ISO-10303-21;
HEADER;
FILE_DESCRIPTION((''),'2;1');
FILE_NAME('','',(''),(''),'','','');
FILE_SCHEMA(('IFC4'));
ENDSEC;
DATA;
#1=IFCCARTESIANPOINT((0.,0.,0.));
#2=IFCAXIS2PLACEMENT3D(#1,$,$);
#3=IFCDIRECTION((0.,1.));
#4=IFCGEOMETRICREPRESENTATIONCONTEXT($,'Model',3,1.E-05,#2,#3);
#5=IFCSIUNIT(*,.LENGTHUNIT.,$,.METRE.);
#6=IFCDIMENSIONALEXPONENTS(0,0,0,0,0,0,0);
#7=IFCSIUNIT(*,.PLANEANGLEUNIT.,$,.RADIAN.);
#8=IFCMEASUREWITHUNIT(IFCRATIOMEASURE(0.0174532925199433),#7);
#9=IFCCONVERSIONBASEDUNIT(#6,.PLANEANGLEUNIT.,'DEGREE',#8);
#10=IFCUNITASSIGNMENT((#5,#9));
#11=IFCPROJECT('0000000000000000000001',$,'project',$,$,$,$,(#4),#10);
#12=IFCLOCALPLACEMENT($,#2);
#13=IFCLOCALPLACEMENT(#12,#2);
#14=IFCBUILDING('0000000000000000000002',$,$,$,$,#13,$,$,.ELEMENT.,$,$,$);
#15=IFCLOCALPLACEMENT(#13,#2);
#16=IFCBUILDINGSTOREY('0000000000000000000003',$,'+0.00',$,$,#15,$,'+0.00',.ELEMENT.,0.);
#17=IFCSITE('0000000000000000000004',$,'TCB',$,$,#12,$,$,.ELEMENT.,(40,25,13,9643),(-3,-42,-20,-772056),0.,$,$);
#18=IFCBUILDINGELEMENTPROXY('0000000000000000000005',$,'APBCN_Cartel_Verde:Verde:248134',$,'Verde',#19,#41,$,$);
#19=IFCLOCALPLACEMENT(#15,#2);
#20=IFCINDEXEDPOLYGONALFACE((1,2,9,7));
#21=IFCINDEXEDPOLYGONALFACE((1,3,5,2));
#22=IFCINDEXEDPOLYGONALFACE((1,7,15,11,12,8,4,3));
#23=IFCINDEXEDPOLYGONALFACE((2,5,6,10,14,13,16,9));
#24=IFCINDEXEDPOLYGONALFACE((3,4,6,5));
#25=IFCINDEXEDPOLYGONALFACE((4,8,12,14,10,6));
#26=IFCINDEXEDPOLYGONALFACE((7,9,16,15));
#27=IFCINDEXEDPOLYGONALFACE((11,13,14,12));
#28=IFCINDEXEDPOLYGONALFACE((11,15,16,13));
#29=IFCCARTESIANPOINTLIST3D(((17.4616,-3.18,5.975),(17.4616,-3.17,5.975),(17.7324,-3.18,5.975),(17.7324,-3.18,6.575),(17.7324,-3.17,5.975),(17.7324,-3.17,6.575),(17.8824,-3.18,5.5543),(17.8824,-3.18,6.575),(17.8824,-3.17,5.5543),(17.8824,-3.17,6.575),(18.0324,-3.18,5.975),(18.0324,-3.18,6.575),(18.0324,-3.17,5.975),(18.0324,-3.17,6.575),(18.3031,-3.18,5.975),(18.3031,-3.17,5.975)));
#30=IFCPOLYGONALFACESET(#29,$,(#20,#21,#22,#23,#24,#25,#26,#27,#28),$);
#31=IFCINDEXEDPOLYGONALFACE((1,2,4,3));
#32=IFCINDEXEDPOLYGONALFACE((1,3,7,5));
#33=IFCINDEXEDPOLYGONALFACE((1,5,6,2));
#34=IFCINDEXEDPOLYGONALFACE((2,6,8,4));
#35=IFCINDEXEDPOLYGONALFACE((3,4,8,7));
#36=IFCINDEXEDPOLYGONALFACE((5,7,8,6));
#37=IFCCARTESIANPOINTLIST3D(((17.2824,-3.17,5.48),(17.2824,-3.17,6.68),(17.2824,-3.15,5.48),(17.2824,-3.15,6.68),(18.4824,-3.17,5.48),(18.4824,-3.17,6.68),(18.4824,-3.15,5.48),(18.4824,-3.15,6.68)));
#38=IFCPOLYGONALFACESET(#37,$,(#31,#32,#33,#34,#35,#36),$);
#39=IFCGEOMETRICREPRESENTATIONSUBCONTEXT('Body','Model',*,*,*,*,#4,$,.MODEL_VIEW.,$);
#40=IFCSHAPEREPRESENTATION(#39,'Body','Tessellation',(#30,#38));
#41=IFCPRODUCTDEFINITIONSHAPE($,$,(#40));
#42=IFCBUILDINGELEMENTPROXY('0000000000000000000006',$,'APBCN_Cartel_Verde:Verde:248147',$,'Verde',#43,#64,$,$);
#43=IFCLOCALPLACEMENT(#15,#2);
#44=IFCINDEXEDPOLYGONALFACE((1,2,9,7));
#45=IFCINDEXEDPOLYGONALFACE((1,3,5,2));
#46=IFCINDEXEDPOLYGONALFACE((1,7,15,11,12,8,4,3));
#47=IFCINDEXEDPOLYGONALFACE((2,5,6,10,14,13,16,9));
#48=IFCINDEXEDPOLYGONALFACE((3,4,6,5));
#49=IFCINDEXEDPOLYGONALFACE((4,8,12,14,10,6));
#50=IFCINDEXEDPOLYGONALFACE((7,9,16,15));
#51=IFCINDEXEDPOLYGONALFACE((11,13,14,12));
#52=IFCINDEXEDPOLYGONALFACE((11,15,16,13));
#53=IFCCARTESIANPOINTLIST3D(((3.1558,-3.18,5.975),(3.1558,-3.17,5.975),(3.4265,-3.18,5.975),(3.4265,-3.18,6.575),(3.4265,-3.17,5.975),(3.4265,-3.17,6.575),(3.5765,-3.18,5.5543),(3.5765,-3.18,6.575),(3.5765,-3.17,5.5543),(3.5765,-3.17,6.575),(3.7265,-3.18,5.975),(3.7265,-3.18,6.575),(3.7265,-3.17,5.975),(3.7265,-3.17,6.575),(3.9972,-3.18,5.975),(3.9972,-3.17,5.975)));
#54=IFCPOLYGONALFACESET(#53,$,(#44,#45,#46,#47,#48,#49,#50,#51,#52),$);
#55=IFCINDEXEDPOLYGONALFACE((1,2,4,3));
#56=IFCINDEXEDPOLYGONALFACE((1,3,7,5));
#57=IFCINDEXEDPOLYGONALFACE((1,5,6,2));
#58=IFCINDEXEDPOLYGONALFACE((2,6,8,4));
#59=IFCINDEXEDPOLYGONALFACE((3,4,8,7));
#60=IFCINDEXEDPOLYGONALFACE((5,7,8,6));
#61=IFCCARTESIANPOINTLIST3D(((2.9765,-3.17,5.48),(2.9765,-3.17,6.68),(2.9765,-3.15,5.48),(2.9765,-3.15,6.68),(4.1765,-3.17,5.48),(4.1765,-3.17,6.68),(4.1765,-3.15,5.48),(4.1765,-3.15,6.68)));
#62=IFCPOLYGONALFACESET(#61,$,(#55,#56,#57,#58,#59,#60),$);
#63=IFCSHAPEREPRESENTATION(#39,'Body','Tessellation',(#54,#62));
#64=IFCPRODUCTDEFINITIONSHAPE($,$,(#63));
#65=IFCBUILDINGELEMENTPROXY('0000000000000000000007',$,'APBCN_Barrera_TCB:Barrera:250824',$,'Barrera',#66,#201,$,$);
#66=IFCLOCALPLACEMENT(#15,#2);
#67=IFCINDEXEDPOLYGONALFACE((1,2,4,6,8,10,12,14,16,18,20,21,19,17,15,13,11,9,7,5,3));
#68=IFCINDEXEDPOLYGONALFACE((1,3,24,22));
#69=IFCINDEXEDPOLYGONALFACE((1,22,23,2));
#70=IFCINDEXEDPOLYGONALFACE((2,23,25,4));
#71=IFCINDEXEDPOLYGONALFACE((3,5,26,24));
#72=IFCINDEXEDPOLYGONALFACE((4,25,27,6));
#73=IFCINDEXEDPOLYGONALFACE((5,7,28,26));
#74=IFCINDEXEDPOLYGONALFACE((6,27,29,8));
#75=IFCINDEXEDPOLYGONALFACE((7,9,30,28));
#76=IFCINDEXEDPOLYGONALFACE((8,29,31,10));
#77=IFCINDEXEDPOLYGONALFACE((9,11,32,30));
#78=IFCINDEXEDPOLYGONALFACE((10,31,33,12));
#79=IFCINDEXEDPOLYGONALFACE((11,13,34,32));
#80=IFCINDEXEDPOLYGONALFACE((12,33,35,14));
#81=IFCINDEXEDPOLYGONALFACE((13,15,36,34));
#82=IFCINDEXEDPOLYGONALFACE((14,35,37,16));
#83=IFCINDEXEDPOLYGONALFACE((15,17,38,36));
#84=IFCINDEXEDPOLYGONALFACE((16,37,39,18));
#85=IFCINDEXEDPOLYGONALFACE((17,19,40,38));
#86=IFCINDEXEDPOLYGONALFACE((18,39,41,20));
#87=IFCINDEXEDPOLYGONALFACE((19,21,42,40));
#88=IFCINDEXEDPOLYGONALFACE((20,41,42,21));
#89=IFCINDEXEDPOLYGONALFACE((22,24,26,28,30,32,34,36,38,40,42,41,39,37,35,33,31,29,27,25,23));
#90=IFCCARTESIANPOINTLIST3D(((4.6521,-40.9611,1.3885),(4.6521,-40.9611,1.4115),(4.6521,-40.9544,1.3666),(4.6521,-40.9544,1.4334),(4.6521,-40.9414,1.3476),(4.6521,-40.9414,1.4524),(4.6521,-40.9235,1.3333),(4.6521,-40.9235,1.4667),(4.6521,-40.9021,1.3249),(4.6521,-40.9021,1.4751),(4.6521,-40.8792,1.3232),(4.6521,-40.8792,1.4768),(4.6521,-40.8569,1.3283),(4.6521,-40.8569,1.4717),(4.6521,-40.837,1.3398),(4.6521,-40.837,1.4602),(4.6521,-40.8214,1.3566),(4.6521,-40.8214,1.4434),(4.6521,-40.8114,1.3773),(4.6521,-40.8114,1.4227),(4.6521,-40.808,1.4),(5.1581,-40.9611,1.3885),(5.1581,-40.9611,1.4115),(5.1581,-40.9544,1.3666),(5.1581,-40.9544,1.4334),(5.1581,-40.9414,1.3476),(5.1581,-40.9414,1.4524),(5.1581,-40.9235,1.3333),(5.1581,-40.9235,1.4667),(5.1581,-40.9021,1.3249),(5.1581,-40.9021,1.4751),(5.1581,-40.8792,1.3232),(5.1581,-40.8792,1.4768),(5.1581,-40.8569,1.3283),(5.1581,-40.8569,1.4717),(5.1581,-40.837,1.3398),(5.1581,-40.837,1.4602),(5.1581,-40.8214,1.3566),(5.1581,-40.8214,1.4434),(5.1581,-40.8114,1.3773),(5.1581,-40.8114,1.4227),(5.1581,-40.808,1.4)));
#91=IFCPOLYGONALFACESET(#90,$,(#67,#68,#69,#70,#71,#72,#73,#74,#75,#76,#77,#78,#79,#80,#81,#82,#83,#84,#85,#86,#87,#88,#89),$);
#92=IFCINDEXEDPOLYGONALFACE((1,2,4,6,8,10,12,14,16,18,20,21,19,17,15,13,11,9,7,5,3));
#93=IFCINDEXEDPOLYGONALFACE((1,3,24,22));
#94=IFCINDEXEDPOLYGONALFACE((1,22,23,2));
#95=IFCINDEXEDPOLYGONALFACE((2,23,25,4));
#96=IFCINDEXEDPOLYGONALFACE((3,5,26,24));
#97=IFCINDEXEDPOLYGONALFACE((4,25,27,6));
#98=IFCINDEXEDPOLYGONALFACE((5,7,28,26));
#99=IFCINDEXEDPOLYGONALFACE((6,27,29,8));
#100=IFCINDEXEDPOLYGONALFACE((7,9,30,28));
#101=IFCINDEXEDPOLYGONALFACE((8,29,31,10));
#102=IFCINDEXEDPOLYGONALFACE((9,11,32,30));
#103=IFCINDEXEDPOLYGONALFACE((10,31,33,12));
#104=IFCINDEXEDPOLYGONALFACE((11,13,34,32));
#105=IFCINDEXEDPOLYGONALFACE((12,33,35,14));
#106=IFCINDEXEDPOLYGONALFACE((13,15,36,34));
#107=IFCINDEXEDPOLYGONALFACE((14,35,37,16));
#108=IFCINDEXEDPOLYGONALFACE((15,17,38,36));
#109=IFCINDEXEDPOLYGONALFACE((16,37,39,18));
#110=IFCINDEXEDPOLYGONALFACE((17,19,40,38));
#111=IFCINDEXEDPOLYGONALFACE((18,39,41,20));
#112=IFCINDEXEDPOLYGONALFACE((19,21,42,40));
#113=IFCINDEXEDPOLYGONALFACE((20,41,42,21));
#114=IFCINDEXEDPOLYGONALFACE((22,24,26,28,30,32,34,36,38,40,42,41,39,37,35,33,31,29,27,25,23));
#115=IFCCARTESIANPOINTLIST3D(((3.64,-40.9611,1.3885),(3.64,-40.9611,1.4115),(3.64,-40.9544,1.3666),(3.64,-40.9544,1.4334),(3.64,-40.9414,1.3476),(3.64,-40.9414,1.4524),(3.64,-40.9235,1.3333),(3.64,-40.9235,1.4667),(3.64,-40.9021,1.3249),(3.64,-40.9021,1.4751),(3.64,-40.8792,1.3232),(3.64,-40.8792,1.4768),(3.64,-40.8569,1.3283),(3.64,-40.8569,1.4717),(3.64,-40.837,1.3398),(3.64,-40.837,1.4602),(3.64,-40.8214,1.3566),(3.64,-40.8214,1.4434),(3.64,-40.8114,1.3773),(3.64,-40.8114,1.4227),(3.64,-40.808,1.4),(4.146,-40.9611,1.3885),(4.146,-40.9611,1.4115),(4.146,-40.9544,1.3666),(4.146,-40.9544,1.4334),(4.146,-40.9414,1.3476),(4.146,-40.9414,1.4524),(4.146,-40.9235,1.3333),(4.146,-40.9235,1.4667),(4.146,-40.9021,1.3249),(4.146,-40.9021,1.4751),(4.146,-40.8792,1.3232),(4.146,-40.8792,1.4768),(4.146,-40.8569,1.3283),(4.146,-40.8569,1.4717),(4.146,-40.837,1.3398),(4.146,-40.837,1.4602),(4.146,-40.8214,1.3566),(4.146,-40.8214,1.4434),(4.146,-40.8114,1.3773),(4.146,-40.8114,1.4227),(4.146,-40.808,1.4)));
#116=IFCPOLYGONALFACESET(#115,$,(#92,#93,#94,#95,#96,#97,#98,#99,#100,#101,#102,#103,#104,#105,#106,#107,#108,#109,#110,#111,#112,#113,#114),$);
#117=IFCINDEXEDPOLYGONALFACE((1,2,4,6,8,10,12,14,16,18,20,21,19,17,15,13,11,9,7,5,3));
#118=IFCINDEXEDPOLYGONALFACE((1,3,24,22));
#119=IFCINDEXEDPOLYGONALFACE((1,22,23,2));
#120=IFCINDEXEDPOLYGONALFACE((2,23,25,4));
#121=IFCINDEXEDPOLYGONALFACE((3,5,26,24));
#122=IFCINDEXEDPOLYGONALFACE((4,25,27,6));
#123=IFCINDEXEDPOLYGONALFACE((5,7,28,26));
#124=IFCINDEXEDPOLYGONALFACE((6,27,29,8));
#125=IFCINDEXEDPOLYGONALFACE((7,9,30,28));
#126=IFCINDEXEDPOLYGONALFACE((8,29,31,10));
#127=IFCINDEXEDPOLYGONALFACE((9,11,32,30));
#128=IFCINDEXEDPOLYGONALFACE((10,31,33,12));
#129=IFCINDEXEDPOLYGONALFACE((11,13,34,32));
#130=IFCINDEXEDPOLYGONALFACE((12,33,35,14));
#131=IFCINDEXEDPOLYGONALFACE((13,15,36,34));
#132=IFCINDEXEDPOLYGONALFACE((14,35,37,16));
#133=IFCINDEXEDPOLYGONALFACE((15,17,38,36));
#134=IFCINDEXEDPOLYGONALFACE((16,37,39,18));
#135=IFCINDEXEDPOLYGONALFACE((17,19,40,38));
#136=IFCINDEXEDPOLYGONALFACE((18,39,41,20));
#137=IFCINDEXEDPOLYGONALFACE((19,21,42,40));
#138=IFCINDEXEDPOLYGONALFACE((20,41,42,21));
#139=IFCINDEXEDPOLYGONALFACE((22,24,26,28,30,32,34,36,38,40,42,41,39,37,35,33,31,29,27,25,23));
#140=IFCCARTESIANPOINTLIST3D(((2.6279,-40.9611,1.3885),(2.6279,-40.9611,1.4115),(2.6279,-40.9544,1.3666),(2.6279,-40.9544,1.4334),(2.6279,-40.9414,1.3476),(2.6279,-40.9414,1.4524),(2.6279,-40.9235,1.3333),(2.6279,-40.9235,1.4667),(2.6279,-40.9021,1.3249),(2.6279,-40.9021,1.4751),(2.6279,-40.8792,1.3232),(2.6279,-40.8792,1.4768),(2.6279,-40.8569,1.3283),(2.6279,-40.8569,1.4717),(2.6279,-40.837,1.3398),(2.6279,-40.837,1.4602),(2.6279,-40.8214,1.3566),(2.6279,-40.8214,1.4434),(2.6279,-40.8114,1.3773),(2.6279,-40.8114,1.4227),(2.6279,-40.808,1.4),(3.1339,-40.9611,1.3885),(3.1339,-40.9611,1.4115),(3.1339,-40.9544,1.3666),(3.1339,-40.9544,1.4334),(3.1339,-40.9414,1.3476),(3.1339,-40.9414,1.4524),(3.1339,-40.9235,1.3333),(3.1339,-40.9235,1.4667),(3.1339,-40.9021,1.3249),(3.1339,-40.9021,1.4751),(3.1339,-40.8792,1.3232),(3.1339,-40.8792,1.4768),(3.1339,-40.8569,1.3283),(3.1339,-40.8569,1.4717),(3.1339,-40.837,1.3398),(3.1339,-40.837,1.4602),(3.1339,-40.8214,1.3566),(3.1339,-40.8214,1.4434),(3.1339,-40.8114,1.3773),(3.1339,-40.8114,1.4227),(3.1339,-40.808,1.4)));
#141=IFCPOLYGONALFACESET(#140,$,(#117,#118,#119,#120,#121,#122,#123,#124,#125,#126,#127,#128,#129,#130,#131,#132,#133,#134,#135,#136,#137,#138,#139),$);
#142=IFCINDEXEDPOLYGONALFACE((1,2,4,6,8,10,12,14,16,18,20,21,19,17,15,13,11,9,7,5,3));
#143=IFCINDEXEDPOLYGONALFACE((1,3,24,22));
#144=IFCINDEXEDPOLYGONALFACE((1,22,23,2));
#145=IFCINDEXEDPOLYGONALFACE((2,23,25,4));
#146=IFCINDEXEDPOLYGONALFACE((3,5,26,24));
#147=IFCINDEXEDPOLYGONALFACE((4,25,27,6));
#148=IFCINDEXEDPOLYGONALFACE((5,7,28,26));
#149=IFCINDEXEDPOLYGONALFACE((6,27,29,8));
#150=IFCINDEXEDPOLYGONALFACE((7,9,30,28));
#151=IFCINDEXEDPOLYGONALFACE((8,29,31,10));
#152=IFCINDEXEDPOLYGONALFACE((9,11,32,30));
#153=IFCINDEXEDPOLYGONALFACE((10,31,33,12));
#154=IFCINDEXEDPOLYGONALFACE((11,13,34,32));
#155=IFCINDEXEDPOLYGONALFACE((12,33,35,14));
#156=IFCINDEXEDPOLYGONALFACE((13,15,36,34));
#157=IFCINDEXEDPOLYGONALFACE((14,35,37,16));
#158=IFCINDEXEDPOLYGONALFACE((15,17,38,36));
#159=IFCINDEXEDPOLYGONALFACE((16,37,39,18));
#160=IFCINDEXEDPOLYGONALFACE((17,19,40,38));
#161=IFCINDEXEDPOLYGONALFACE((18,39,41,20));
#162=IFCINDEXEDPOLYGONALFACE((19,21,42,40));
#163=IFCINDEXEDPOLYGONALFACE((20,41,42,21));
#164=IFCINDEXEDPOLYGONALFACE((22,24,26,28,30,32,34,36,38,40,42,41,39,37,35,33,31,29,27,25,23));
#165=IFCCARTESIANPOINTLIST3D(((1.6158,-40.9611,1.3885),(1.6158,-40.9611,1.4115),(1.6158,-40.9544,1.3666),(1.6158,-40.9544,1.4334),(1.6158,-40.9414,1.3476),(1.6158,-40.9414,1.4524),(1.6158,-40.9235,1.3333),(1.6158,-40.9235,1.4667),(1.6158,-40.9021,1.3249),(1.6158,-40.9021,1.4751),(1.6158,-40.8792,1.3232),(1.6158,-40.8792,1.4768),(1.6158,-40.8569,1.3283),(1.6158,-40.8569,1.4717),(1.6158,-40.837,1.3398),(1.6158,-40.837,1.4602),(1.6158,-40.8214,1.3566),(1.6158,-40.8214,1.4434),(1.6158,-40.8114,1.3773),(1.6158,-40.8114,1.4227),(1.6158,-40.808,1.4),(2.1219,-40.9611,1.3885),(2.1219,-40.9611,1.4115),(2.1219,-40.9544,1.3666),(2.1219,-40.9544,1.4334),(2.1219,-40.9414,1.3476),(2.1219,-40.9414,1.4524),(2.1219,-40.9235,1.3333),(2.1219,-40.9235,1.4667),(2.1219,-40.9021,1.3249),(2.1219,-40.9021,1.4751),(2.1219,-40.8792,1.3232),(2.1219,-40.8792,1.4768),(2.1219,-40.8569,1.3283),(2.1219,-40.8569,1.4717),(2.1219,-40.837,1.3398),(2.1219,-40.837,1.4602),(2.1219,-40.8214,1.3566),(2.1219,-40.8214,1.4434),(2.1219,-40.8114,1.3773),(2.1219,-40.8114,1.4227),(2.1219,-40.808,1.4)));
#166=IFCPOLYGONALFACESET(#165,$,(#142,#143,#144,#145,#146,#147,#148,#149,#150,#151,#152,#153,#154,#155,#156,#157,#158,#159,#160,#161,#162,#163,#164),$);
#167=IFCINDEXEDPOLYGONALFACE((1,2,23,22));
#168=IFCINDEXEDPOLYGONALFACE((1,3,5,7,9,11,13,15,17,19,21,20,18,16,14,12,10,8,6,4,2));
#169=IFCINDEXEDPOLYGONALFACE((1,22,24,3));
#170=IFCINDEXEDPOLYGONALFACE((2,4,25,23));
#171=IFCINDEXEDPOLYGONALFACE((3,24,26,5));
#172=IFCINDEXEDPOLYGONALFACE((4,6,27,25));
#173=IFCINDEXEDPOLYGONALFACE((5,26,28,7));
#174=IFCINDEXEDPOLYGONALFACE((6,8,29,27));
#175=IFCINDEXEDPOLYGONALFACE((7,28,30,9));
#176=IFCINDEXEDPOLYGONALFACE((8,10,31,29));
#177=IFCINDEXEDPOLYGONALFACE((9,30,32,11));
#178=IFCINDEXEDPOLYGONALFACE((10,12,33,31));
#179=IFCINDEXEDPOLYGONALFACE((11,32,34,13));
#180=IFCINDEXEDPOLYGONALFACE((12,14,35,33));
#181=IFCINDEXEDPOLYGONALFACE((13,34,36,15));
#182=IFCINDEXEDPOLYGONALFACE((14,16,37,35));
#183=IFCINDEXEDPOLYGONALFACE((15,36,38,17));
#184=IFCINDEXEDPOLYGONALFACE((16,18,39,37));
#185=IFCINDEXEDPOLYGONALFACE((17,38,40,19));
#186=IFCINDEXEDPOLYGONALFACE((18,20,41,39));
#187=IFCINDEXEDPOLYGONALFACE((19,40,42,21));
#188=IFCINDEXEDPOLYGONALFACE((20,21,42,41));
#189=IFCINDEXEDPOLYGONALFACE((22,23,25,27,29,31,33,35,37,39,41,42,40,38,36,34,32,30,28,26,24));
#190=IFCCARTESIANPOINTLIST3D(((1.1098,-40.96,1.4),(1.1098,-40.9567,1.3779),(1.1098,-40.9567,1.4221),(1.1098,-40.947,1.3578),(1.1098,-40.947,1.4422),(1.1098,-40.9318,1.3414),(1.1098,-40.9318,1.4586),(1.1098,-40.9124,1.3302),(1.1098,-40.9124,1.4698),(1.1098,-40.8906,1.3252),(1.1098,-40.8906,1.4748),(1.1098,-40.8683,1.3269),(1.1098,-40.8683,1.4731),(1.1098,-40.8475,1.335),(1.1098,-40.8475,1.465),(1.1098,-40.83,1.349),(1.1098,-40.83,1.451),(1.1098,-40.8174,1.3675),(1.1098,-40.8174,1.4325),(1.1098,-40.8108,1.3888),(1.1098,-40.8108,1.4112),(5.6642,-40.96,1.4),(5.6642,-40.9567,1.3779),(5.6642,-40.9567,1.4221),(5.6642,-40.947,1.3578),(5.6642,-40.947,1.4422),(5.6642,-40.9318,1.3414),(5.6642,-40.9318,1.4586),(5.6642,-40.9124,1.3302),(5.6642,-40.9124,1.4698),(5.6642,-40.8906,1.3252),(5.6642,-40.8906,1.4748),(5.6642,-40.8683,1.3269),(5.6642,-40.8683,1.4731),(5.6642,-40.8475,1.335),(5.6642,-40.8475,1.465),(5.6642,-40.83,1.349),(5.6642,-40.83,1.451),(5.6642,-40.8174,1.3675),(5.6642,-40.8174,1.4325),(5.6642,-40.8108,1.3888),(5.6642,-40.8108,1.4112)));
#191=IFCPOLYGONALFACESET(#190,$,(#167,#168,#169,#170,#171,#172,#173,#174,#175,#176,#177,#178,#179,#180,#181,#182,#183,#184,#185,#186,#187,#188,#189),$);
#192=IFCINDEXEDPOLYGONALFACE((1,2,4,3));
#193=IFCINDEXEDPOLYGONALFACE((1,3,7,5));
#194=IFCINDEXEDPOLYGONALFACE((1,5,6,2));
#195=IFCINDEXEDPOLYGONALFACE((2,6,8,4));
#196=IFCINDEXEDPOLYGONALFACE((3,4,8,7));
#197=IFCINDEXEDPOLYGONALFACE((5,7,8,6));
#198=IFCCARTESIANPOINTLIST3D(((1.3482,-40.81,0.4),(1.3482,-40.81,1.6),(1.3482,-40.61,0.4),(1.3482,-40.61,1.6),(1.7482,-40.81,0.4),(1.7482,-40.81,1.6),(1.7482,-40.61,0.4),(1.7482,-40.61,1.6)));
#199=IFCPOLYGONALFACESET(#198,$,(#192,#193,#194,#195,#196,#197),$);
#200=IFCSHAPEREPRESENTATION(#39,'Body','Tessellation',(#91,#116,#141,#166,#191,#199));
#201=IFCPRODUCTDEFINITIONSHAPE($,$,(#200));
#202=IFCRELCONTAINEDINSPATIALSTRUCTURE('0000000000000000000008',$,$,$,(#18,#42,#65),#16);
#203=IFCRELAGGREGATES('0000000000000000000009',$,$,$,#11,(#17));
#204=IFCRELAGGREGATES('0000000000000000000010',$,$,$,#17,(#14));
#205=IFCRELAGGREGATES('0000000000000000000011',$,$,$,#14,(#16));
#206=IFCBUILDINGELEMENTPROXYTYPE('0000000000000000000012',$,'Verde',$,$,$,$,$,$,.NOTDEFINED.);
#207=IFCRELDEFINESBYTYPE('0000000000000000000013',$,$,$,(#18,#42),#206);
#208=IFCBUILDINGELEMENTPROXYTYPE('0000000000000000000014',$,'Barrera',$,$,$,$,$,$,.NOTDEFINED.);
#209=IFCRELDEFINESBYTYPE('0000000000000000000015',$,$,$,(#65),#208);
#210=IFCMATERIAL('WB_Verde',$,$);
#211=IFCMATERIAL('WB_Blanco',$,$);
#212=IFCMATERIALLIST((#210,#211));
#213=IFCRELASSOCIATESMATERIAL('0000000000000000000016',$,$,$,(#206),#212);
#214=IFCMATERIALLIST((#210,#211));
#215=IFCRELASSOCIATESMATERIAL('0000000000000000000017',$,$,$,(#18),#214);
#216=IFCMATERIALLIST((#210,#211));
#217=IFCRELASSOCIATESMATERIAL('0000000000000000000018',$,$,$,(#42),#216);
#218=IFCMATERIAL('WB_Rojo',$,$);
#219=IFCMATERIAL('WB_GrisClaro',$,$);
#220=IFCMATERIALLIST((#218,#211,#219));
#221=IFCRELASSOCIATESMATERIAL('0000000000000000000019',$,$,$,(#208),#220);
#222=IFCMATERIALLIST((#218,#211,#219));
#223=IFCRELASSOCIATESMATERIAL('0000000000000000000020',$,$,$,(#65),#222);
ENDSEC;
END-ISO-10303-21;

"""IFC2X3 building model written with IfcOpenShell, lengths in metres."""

from ifc_helpers import new_model, entity, si_unit, converted_unit, direction, frame, frame_2d, origin, origin_2d_with_axis, place, context, subcontext, project, spatial, polyline, rectangle, circle, outline, extrude, source, transform, mapped, material, material_list, type_object, type_shapes, element, save


model = new_model("IFC2X3")

# Units and contexts
model_context = context("Model", 3, precision=1e-05, world=origin(), true_north=direction((0.0, 1.0)))
body_context = subcontext(model_context, "Body", "Model", "MODEL_VIEW")
ifc_project = project(units=[si_unit("LENGTHUNIT", "METRE"), converted_unit("PLANEANGLEUNIT", "DEGREE", entity("IfcRatioMeasure", 0.0174532925199433), si_unit("PLANEANGLEUNIT", "RADIAN"), dimensions=[0, 0, 0, 0, 0, 0, 0])], contexts=[model_context])

# Site, building, storey
site_placement = place(None, origin())
site = spatial("IfcSite", under=ifc_project, at=site_placement, Name="TCB", CompositionType="ELEMENT", RefLatitude=(40, 25, 13, 9643), RefLongitude=(-3, -42, -20, -772056), RefElevation=0.0)
building_placement = place(site_placement, origin())
building = spatial("IfcBuilding", under=site, at=building_placement, CompositionType="ELEMENT")
storey_placement = place(building_placement, origin())
storey = spatial("IfcBuildingStorey", under=building, at=storey_placement, Name="+0.00", LongName="+0.00", CompositionType="ELEMENT", Elevation=0.0)

# Shared definitions
ifc_material_1 = material(Name="WB_Blanco")

# Shared definitions
ifc_material_2 = material(Name="WB_GrisClaro")

# Building element proxies
ifc_material_3 = material(Name="WB_Rojo")
ifc_material_4 = material(Name="WB_Verde")
ifc_material_list_1 = material_list([ifc_material_4, ifc_material_1])
ifc_material_list_2 = material_list([ifc_material_4, ifc_material_1])
building_element_proxy_type_1 = type_object("IfcBuildingElementProxyType", Name="Verde", PredefinedType="NOTDEFINED", material=ifc_material_list_2)
shared_shape_1 = source(origin(), body_context, "Body", "SweptSolid", [
    extrude(outline(polyline([(-0.15, -0.4276), (0.0, -0.4276), (0.15, -0.4276), (0.15, 0.1724), (0.4207, 0.1724), (0.0, 0.5931), (-0.4207, 0.1724), (-0.15, 0.1724), (-0.15, -0.4276)])), frame((0.0, 0.0674, 0.02), z_axis=(0.0, 0.0, 1.0), x_axis=(-1.0, 0.0, 0.0)), (0.0, 0.0, 1.0), 0.01),
    extrude(rectangle(XDim=1.2, YDim=1.2, at=origin_2d_with_axis()), origin(), (0.0, 0.0, 1.0), 0.02),
])
type_shapes(building_element_proxy_type_1, [shared_shape_1])
proxy_1_placement = place(storey_placement, frame((17.8824, -3.15, 6.08), z_axis=(0.0, -1.0, 0.0), x_axis=(1.0, 0.0, 0.0)))
element("IfcBuildingElementProxy", 1, at=proxy_1_placement, inside=storey, type_object=building_element_proxy_type_1, material=ifc_material_list_1, Name="APBCN_Cartel_Verde:Verde:248134", ObjectType="Verde", context=body_context, shape_type="MappedRepresentation", body=[
    mapped(shared_shape_1, transform((0.0, 0.0, 0.0), scale=1.0)),
])
ifc_material_list_3 = material_list([ifc_material_4, ifc_material_1])
proxy_2_placement = place(storey_placement, frame((3.5765, -3.15, 6.08), z_axis=(0.0, -1.0, 0.0), x_axis=(1.0, 0.0, 0.0)))
element("IfcBuildingElementProxy", 2, at=proxy_2_placement, inside=storey, type_object=building_element_proxy_type_1, material=ifc_material_list_3, Name="APBCN_Cartel_Verde:Verde:248147", ObjectType="Verde", context=body_context, shape_type="MappedRepresentation", body=[
    mapped(shared_shape_1, transform((0.0, 0.0, 0.0), scale=1.0)),
])
ifc_material_list_4 = material_list([ifc_material_3, ifc_material_1, ifc_material_2])
ifc_material_list_5 = material_list([ifc_material_3, ifc_material_1, ifc_material_2])
building_element_proxy_type_2 = type_object("IfcBuildingElementProxyType", Name="Barrera", PredefinedType="NOTDEFINED", material=ifc_material_list_5)
shared_shape_2 = source(origin(), body_context, "Body", "SweptSolid", [
    extrude(circle(Radius=0.077, at=frame_2d((0.0, 0.0), x_axis=(1.0, 0.0))), frame((2.8039, -0.175, 1.0), z_axis=(1.0, 0.0, 0.0), x_axis=(0.0, 1.0, 0.0)), (0.0, 0.0, 1.0), 0.506),
    extrude(circle(Radius=0.077, at=frame_2d((0.0, 0.0), x_axis=(1.0, 0.0))), frame((1.7918, -0.175, 1.0), z_axis=(1.0, 0.0, 0.0), x_axis=(0.0, 1.0, 0.0)), (0.0, 0.0, 1.0), 0.506),
    extrude(circle(Radius=0.077, at=frame_2d((0.0, 0.0), x_axis=(1.0, 0.0))), frame((0.7797, -0.175, 1.0), z_axis=(1.0, 0.0, 0.0), x_axis=(0.0, 1.0, 0.0)), (0.0, 0.0, 1.0), 0.506),
    extrude(circle(Radius=0.077, at=frame_2d((0.0, 0.0), x_axis=(1.0, 0.0))), frame((-0.2324, -0.175, 1.0), z_axis=(1.0, 0.0, 0.0), x_axis=(0.0, 1.0, 0.0)), (0.0, 0.0, 1.0), 0.506),
    extrude(circle(Radius=0.075, at=frame_2d((0.0, 0.0), x_axis=(1.0, 0.0))), frame((-0.7385, -0.175, 1.0), z_axis=(1.0, 0.0, 0.0), x_axis=(0.0, -1.0, 0.0)), (0.0, 0.0, 1.0), 4.5544),
    extrude(rectangle(XDim=0.2, YDim=0.4, at=frame_2d((0.0, 0.0), x_axis=(1.0, 0.0))), frame((-0.3, 0.0, 0.0), z_axis=(0.0, 0.0, 1.0), x_axis=(0.0, -1.0, 0.0)), (0.0, 0.0, 1.0), 1.2),
])
type_shapes(building_element_proxy_type_2, [shared_shape_2])
proxy_3_placement = place(storey_placement, frame((1.8482, -40.71, 0.4)))
element("IfcBuildingElementProxy", 3, at=proxy_3_placement, inside=storey, type_object=building_element_proxy_type_2, material=ifc_material_list_4, Name="APBCN_Barrera_TCB:Barrera:250824", ObjectType="Barrera", context=body_context, shape_type="MappedRepresentation", body=[
    mapped(shared_shape_2, transform((0.0, 0.0, 0.0), scale=1.0)),
])

save(model, "model.ifc")
